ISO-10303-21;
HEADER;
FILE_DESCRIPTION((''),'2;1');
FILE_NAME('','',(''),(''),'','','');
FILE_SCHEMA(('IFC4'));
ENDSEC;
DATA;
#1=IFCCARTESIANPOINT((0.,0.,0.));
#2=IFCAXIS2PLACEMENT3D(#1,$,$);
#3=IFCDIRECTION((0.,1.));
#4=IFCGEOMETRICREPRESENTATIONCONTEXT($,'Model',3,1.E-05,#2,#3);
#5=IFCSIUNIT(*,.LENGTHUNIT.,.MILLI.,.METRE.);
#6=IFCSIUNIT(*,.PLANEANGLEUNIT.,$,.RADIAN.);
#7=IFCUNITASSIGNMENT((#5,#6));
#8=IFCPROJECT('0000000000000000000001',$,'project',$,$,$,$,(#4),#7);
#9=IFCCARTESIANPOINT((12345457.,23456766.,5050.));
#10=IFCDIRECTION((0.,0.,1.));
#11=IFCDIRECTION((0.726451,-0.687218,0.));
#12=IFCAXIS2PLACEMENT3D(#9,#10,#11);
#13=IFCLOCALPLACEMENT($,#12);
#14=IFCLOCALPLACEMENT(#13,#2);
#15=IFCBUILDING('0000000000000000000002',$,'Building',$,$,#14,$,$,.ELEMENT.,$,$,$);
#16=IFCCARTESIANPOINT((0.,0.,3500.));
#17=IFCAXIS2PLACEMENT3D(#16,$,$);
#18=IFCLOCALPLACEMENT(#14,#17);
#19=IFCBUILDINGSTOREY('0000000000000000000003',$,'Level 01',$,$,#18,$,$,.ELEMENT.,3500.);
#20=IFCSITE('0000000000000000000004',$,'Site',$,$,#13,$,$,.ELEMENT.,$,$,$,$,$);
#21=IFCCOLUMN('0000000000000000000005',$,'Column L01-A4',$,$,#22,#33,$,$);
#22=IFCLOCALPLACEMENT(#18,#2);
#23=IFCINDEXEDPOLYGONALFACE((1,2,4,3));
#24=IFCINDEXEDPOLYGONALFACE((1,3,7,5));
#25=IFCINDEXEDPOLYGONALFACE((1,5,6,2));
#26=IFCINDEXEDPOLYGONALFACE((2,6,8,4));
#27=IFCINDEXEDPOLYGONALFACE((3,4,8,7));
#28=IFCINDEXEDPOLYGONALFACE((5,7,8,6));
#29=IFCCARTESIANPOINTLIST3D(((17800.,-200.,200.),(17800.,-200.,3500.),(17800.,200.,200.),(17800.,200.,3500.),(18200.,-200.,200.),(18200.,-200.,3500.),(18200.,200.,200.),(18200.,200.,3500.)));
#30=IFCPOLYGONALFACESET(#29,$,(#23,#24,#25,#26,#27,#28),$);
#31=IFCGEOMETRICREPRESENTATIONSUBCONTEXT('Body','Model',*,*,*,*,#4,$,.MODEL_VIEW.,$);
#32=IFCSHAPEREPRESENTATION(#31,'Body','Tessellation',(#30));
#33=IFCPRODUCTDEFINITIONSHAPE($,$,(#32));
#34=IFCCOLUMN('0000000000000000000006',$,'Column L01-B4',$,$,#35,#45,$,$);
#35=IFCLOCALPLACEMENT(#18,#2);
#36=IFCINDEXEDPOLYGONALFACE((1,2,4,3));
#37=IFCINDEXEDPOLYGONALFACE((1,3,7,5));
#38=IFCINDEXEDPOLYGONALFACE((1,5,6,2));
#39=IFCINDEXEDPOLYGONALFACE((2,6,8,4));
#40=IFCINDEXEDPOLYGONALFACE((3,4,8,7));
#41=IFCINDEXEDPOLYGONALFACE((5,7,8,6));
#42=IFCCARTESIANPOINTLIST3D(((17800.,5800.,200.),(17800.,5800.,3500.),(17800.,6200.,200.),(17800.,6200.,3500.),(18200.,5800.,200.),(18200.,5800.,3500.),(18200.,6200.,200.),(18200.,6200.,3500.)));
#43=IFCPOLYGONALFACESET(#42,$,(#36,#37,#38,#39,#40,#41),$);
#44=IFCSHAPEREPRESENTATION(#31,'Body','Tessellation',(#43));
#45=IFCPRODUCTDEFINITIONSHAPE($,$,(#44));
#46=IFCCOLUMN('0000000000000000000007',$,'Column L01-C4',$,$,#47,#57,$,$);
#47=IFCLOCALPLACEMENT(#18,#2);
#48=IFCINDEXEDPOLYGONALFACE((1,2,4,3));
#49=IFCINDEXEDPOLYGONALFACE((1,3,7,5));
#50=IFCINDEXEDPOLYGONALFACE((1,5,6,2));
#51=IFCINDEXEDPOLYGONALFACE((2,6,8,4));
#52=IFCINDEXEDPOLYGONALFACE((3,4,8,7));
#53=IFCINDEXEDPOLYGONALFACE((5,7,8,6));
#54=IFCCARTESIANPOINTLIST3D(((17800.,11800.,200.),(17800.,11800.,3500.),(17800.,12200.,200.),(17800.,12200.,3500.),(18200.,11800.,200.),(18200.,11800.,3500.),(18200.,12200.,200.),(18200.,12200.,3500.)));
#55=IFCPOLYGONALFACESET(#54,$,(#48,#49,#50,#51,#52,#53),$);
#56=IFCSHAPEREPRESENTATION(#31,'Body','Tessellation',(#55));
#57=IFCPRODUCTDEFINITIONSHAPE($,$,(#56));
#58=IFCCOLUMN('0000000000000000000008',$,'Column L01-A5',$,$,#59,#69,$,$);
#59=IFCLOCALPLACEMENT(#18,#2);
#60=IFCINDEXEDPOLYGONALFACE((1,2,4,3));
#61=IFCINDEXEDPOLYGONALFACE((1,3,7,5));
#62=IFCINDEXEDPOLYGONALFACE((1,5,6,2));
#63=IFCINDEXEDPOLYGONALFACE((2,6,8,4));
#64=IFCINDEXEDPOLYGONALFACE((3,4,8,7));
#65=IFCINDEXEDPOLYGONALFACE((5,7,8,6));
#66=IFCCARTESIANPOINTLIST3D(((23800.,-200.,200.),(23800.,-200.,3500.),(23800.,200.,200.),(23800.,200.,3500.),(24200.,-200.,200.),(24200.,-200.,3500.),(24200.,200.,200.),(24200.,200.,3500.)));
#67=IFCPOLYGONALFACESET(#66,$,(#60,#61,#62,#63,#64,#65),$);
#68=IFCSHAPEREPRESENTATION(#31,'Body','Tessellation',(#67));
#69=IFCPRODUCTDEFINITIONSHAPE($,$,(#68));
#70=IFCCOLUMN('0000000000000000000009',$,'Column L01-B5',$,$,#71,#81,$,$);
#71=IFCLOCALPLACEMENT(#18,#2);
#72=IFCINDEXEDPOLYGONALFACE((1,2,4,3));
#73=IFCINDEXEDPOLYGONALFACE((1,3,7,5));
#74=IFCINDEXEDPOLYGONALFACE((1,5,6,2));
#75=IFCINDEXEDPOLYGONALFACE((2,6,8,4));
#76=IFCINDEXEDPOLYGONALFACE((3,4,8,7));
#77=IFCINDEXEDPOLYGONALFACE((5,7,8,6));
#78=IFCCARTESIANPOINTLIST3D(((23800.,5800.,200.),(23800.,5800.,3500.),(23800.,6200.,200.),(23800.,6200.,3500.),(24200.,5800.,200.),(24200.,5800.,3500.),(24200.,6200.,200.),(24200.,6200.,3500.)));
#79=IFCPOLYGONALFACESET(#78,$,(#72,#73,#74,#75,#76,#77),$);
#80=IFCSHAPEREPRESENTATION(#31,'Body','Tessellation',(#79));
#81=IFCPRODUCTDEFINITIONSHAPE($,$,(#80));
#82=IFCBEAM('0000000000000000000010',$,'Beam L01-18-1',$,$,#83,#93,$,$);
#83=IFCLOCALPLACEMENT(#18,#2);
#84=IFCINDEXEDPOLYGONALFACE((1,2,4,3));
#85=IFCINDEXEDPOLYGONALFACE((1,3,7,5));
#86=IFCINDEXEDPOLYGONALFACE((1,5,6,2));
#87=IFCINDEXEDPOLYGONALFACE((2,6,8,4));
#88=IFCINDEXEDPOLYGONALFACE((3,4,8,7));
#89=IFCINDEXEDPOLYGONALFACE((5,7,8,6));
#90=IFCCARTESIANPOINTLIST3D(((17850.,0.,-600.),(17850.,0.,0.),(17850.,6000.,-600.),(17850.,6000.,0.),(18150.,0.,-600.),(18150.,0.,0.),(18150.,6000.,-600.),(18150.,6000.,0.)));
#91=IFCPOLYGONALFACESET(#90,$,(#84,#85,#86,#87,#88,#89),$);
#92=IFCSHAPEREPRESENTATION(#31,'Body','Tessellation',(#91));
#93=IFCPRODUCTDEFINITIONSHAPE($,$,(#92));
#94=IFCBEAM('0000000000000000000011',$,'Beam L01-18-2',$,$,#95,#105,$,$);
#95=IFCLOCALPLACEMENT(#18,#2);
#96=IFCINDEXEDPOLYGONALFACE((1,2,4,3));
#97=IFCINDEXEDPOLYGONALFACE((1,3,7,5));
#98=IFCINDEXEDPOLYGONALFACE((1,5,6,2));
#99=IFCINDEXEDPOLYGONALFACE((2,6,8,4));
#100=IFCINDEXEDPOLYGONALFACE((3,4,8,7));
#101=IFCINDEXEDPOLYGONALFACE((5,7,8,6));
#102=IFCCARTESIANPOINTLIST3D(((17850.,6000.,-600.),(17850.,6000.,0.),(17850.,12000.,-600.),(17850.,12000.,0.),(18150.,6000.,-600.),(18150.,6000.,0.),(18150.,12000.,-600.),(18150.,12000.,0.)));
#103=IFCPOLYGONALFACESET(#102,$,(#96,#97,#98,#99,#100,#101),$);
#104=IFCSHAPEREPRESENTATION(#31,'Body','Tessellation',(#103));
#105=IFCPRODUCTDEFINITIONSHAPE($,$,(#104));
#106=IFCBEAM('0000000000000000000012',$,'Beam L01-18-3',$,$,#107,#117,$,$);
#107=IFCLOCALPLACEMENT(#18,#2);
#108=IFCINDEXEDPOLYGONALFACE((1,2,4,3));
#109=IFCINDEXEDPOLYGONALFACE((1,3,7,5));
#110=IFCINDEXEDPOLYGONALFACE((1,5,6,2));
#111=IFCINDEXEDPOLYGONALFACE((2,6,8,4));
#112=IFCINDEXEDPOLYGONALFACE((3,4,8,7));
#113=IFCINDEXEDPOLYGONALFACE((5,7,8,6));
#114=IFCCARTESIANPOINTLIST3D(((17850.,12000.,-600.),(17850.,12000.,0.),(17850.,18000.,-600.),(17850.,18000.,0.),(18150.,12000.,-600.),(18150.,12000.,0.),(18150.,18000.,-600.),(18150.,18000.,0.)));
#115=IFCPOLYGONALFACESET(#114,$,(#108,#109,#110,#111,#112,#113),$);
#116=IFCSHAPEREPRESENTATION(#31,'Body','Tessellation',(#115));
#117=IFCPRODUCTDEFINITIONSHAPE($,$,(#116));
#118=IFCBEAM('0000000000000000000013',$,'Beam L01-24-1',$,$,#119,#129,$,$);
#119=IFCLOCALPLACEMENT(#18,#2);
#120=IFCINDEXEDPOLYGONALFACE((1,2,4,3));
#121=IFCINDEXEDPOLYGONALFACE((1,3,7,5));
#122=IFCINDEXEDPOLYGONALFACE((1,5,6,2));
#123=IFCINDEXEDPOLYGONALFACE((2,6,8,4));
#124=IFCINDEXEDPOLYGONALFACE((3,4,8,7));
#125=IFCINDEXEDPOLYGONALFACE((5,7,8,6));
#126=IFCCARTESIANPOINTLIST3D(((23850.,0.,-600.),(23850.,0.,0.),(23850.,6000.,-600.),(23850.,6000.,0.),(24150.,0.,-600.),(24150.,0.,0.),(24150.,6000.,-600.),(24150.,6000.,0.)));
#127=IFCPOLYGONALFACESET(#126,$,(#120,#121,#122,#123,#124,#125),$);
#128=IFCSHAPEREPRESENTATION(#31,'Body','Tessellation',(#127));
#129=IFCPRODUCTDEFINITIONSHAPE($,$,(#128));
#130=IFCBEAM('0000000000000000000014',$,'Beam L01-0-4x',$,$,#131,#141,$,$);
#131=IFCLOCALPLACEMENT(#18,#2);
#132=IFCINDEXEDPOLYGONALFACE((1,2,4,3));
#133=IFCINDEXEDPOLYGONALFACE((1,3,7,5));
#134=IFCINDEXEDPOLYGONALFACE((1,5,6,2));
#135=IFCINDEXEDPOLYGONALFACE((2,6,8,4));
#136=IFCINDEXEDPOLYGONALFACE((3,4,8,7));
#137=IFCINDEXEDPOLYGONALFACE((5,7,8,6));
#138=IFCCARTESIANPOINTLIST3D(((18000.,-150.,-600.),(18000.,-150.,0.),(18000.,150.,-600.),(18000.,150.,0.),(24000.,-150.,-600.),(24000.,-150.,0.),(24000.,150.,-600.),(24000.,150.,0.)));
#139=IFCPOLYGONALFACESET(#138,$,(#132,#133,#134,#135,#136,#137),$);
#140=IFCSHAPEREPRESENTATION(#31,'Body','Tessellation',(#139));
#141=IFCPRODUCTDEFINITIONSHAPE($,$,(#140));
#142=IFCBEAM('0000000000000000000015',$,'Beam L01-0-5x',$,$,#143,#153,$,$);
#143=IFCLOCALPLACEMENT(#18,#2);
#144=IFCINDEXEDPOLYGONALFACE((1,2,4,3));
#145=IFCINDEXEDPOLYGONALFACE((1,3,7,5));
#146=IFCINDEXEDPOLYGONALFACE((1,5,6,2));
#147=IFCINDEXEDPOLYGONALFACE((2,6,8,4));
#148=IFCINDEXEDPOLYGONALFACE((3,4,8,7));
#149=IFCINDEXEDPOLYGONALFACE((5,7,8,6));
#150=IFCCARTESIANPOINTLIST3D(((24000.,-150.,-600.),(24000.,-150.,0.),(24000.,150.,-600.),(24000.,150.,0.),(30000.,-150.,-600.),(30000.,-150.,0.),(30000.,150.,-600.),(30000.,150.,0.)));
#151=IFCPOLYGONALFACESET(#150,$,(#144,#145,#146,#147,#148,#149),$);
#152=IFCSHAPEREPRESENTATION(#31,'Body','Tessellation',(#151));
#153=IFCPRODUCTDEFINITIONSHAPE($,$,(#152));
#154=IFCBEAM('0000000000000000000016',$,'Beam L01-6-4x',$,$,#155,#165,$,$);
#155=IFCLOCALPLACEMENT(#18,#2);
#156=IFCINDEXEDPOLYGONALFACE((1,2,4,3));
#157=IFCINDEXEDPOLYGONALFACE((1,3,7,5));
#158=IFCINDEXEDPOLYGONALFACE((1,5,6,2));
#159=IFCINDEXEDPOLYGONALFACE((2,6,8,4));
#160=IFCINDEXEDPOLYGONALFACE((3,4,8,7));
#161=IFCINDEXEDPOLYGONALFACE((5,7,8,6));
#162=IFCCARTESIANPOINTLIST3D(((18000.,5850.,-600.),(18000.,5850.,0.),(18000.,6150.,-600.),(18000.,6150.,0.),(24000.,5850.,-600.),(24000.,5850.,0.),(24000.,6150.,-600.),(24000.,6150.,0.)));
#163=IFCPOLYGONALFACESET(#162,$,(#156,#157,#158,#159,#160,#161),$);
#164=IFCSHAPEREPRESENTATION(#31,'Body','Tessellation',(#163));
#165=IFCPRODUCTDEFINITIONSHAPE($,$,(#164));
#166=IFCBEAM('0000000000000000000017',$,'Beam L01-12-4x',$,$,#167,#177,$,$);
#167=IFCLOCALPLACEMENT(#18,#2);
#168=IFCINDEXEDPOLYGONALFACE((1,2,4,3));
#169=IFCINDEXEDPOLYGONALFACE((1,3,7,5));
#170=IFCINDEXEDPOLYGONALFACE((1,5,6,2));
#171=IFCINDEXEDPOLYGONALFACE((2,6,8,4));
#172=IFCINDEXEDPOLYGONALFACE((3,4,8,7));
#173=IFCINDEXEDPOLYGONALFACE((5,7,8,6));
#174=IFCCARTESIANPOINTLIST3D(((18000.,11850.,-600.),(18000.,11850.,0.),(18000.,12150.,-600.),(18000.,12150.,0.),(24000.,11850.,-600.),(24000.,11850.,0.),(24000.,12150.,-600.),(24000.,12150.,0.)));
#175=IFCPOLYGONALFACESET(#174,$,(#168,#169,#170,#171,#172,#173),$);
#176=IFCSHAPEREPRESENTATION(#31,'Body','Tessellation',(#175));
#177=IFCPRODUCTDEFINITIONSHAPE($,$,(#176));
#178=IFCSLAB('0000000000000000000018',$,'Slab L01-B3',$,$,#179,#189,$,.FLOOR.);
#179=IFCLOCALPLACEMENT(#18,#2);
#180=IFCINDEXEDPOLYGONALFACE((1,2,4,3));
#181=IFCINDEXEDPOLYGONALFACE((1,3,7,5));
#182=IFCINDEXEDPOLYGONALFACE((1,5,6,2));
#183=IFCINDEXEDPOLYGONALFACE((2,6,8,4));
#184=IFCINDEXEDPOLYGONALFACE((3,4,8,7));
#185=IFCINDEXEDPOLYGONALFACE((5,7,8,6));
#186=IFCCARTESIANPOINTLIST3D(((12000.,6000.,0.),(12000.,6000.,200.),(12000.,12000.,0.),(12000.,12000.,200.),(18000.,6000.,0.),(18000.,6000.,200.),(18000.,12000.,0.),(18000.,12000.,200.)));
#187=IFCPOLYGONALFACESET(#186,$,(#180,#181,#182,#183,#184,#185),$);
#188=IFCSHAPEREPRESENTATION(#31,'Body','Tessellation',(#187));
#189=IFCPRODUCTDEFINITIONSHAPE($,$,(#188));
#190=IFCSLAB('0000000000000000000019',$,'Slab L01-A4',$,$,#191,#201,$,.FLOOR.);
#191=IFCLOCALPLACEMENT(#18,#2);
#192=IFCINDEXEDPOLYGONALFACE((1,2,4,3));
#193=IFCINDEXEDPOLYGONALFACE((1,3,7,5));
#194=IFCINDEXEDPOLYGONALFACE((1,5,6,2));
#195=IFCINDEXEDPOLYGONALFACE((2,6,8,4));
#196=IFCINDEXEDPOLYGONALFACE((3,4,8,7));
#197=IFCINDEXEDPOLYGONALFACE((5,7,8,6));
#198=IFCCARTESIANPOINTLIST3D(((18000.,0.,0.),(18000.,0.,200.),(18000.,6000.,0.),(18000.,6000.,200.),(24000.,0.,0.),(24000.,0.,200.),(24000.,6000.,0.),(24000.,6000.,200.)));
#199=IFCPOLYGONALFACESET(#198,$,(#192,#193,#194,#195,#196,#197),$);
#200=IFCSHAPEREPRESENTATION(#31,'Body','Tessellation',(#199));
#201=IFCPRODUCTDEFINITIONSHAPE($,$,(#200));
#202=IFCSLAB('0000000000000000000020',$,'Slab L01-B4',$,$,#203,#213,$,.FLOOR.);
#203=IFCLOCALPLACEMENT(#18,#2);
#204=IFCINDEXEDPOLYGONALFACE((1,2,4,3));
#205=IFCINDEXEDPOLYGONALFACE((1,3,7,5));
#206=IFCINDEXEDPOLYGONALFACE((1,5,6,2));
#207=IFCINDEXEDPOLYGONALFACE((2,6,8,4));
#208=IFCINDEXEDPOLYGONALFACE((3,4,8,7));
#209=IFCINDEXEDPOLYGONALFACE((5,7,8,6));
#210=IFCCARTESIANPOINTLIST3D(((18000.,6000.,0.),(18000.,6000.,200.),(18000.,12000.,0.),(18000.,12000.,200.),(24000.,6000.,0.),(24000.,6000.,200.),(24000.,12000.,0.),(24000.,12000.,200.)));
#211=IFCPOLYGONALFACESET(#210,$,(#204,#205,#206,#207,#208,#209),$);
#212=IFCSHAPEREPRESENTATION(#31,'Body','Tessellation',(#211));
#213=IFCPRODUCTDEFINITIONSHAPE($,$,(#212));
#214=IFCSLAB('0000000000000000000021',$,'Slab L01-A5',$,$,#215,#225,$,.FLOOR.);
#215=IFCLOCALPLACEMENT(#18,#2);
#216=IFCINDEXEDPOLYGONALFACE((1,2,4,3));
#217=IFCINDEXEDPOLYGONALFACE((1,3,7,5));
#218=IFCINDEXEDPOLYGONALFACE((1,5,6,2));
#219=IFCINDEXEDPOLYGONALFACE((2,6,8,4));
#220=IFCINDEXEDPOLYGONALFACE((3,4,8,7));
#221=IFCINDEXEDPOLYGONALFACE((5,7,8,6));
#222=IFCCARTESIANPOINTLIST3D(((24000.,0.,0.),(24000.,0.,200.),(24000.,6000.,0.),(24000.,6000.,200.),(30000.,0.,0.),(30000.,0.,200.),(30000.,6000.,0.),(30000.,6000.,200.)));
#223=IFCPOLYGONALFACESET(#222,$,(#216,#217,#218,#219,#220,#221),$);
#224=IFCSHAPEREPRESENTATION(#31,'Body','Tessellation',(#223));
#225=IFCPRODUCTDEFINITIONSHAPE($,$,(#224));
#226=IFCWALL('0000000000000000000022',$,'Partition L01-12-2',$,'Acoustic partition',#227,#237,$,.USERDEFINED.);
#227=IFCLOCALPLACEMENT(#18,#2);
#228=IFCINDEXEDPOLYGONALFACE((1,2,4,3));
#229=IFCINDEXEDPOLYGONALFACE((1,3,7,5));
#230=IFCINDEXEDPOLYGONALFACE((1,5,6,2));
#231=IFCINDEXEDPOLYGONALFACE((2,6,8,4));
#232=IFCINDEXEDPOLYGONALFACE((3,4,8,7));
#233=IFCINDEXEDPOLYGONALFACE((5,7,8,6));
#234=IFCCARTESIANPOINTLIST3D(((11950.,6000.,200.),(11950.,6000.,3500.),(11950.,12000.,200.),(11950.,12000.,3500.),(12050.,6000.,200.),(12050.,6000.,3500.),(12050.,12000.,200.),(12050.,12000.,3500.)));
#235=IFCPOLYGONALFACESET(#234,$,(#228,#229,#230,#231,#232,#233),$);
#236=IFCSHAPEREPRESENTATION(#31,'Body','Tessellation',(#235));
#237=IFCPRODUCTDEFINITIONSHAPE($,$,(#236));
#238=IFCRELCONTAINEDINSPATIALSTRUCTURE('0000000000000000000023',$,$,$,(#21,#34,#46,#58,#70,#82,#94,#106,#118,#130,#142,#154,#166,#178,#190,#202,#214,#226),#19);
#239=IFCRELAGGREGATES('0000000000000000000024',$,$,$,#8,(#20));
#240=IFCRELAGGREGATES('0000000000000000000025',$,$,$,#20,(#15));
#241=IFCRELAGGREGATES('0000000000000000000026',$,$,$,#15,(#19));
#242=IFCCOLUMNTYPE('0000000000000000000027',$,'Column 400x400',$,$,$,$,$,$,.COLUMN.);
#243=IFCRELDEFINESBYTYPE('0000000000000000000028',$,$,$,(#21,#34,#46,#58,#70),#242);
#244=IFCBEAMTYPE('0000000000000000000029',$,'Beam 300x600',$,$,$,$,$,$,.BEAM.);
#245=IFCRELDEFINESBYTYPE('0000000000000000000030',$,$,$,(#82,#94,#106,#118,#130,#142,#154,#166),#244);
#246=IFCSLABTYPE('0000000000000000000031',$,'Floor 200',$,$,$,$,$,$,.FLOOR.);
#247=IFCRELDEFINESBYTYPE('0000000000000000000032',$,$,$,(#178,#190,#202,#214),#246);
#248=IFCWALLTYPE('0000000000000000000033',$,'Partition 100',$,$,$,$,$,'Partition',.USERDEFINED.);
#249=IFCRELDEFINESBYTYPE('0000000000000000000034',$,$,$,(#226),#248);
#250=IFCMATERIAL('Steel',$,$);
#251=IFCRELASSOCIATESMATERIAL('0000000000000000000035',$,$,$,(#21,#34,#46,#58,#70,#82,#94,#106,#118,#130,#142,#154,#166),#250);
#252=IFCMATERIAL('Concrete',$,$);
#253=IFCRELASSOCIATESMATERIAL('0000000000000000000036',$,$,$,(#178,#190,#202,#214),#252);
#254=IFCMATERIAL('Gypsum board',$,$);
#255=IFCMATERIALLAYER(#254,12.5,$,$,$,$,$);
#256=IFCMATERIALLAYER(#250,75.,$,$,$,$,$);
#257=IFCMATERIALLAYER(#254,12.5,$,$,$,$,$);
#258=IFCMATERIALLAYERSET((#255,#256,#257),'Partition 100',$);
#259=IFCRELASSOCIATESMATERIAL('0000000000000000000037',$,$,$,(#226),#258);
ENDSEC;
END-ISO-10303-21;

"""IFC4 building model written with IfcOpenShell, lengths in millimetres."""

from ifc_helpers import new_model, si_unit, direction, frame, origin, place, context, subcontext, project, spatial, rectangle, extrude, material, layer, layer_set, layer_usage, type_object, element, save


model = new_model("IFC4")

# Units and contexts
model_context = context("Model", 3, precision=1e-05, world=origin(), true_north=direction((0.0, 1.0)))
body_context = subcontext(model_context, "Body", "Model", "MODEL_VIEW")
ifc_project = project(units=[si_unit("LENGTHUNIT", "METRE", prefix="MILLI"), si_unit("PLANEANGLEUNIT", "RADIAN")], contexts=[model_context])

# Site, building, storey
site_placement = place(None, frame((12345457.0, 23456766.0, 5050.0), z_axis=(0.0, 0.0, 1.0), x_axis=(0.726451, -0.687218, 0.0)))
site = spatial("IfcSite", under=ifc_project, at=site_placement, Name="Site", CompositionType="ELEMENT")
building_placement = place(site_placement, origin())
building = spatial("IfcBuilding", under=site, at=building_placement, Name="Building", CompositionType="ELEMENT")
storey_placement = place(building_placement, frame((0.0, 0.0, 3500.0)))
storey = spatial("IfcBuildingStorey", under=building, at=storey_placement, Name="Level 01", CompositionType="ELEMENT", Elevation=3500.0)

# Columns
ifc_material_1 = material(Name="Steel")
column_type = type_object("IfcColumnType", Name="Column 400x400", PredefinedType="COLUMN")
for number, where, name in (
    (1, (17800.0, -200.0, 200.0), "Column L01-A4"),
    (2, (17800.0, 5800.0, 200.0), "Column L01-B4"),
    (3, (17800.0, 11800.0, 200.0), "Column L01-C4"),
    (4, (23800.0, -200.0, 200.0), "Column L01-A5"),
    (5, (23800.0, 5800.0, 200.0), "Column L01-B5"),
):
    element("IfcColumn", number, at=place(storey_placement, frame(where)), inside=storey, type_object=column_type, material=ifc_material_1, Name=name, context=body_context, shape_type="SweptSolid", body=[
        extrude(rectangle(XDim=400.0, YDim=400.0), frame((200.0, 200.0, 0.0)), (0.0, 0.0, 1.0), 3300.0),
    ])

# Beams
beam_type = type_object("IfcBeamType", Name="Beam 300x600", PredefinedType="BEAM")
for number, where, name in (
    (6, (17850.0, 0.0, -600.0), "Beam L01-18-1"),
    (7, (17850.0, 6000.0, -600.0), "Beam L01-18-2"),
    (8, (17850.0, 12000.0, -600.0), "Beam L01-18-3"),
    (9, (23850.0, 0.0, -600.0), "Beam L01-24-1"),
):
    element("IfcBeam", number, at=place(storey_placement, frame(where)), inside=storey, type_object=beam_type, material=ifc_material_1, Name=name, context=body_context, shape_type="SweptSolid", body=[
        extrude(rectangle(XDim=300.0, YDim=6000.0), frame((150.0, 3000.0, 0.0)), (0.0, 0.0, 1.0), 600.0),
    ])
for number, where, name in (
    (10, (18000.0, -150.0, -600.0), "Beam L01-0-4x"),
    (11, (24000.0, -150.0, -600.0), "Beam L01-0-5x"),
    (12, (18000.0, 5850.0, -600.0), "Beam L01-6-4x"),
    (13, (18000.0, 11850.0, -600.0), "Beam L01-12-4x"),
):
    element("IfcBeam", number, at=place(storey_placement, frame(where)), inside=storey, type_object=beam_type, material=ifc_material_1, Name=name, context=body_context, shape_type="SweptSolid", body=[
        extrude(rectangle(XDim=6000.0, YDim=300.0), frame((3000.0, 150.0, 0.0)), (0.0, 0.0, 1.0), 600.0),
    ])

# Slabs
ifc_material_2 = material(Name="Concrete")
slab_type = type_object("IfcSlabType", Name="Floor 200", PredefinedType="FLOOR")
for number, where, name in (
    (14, (12000.0, 6000.0, 0.0), "Slab L01-B3"),
    (15, (18000.0, 0.0, 0.0), "Slab L01-A4"),
    (16, (18000.0, 6000.0, 0.0), "Slab L01-B4"),
    (17, (24000.0, 0.0, 0.0), "Slab L01-A5"),
):
    element("IfcSlab", number, at=place(storey_placement, frame(where)), inside=storey, type_object=slab_type, material=ifc_material_2, Name=name, PredefinedType="FLOOR", context=body_context, shape_type="SweptSolid", body=[
        extrude(rectangle(XDim=6000.0, YDim=6000.0), frame((3000.0, 3000.0, 0.0)), (0.0, 0.0, 1.0), 200.0),
    ])

# Wall
ifc_material_3 = material(Name="Gypsum board")
ifc_layer_1 = layer(ifc_material_3, 12.5)
ifc_layer_2 = layer(ifc_material_1, 75.0)
ifc_layer_3 = layer(ifc_material_3, 12.5)
ifc_layer_set = layer_set([ifc_layer_1, ifc_layer_2, ifc_layer_3], Name="Partition 100")
ifc_layer_usage = layer_usage(ifc_layer_set, "AXIS2", "POSITIVE", 0.0)
wall_type = type_object("IfcWallType", Name="Partition 100", ElementType="Partition", PredefinedType="USERDEFINED")
for number, where, name in (
    (18, (11950.0, 6000.0, 200.0), "Partition L01-12-2"),
):
    element("IfcWall", number, at=place(storey_placement, frame(where)), inside=storey, type_object=wall_type, material=ifc_layer_usage, Name=name, ObjectType="Acoustic partition", PredefinedType="USERDEFINED", context=body_context, shape_type="SweptSolid", body=[
        extrude(rectangle(XDim=100.0, YDim=6000.0), frame((50.0, 3000.0, 0.0)), (0.0, 0.0, 1.0), 3300.0),
    ])

save(model, "model.ifc")
